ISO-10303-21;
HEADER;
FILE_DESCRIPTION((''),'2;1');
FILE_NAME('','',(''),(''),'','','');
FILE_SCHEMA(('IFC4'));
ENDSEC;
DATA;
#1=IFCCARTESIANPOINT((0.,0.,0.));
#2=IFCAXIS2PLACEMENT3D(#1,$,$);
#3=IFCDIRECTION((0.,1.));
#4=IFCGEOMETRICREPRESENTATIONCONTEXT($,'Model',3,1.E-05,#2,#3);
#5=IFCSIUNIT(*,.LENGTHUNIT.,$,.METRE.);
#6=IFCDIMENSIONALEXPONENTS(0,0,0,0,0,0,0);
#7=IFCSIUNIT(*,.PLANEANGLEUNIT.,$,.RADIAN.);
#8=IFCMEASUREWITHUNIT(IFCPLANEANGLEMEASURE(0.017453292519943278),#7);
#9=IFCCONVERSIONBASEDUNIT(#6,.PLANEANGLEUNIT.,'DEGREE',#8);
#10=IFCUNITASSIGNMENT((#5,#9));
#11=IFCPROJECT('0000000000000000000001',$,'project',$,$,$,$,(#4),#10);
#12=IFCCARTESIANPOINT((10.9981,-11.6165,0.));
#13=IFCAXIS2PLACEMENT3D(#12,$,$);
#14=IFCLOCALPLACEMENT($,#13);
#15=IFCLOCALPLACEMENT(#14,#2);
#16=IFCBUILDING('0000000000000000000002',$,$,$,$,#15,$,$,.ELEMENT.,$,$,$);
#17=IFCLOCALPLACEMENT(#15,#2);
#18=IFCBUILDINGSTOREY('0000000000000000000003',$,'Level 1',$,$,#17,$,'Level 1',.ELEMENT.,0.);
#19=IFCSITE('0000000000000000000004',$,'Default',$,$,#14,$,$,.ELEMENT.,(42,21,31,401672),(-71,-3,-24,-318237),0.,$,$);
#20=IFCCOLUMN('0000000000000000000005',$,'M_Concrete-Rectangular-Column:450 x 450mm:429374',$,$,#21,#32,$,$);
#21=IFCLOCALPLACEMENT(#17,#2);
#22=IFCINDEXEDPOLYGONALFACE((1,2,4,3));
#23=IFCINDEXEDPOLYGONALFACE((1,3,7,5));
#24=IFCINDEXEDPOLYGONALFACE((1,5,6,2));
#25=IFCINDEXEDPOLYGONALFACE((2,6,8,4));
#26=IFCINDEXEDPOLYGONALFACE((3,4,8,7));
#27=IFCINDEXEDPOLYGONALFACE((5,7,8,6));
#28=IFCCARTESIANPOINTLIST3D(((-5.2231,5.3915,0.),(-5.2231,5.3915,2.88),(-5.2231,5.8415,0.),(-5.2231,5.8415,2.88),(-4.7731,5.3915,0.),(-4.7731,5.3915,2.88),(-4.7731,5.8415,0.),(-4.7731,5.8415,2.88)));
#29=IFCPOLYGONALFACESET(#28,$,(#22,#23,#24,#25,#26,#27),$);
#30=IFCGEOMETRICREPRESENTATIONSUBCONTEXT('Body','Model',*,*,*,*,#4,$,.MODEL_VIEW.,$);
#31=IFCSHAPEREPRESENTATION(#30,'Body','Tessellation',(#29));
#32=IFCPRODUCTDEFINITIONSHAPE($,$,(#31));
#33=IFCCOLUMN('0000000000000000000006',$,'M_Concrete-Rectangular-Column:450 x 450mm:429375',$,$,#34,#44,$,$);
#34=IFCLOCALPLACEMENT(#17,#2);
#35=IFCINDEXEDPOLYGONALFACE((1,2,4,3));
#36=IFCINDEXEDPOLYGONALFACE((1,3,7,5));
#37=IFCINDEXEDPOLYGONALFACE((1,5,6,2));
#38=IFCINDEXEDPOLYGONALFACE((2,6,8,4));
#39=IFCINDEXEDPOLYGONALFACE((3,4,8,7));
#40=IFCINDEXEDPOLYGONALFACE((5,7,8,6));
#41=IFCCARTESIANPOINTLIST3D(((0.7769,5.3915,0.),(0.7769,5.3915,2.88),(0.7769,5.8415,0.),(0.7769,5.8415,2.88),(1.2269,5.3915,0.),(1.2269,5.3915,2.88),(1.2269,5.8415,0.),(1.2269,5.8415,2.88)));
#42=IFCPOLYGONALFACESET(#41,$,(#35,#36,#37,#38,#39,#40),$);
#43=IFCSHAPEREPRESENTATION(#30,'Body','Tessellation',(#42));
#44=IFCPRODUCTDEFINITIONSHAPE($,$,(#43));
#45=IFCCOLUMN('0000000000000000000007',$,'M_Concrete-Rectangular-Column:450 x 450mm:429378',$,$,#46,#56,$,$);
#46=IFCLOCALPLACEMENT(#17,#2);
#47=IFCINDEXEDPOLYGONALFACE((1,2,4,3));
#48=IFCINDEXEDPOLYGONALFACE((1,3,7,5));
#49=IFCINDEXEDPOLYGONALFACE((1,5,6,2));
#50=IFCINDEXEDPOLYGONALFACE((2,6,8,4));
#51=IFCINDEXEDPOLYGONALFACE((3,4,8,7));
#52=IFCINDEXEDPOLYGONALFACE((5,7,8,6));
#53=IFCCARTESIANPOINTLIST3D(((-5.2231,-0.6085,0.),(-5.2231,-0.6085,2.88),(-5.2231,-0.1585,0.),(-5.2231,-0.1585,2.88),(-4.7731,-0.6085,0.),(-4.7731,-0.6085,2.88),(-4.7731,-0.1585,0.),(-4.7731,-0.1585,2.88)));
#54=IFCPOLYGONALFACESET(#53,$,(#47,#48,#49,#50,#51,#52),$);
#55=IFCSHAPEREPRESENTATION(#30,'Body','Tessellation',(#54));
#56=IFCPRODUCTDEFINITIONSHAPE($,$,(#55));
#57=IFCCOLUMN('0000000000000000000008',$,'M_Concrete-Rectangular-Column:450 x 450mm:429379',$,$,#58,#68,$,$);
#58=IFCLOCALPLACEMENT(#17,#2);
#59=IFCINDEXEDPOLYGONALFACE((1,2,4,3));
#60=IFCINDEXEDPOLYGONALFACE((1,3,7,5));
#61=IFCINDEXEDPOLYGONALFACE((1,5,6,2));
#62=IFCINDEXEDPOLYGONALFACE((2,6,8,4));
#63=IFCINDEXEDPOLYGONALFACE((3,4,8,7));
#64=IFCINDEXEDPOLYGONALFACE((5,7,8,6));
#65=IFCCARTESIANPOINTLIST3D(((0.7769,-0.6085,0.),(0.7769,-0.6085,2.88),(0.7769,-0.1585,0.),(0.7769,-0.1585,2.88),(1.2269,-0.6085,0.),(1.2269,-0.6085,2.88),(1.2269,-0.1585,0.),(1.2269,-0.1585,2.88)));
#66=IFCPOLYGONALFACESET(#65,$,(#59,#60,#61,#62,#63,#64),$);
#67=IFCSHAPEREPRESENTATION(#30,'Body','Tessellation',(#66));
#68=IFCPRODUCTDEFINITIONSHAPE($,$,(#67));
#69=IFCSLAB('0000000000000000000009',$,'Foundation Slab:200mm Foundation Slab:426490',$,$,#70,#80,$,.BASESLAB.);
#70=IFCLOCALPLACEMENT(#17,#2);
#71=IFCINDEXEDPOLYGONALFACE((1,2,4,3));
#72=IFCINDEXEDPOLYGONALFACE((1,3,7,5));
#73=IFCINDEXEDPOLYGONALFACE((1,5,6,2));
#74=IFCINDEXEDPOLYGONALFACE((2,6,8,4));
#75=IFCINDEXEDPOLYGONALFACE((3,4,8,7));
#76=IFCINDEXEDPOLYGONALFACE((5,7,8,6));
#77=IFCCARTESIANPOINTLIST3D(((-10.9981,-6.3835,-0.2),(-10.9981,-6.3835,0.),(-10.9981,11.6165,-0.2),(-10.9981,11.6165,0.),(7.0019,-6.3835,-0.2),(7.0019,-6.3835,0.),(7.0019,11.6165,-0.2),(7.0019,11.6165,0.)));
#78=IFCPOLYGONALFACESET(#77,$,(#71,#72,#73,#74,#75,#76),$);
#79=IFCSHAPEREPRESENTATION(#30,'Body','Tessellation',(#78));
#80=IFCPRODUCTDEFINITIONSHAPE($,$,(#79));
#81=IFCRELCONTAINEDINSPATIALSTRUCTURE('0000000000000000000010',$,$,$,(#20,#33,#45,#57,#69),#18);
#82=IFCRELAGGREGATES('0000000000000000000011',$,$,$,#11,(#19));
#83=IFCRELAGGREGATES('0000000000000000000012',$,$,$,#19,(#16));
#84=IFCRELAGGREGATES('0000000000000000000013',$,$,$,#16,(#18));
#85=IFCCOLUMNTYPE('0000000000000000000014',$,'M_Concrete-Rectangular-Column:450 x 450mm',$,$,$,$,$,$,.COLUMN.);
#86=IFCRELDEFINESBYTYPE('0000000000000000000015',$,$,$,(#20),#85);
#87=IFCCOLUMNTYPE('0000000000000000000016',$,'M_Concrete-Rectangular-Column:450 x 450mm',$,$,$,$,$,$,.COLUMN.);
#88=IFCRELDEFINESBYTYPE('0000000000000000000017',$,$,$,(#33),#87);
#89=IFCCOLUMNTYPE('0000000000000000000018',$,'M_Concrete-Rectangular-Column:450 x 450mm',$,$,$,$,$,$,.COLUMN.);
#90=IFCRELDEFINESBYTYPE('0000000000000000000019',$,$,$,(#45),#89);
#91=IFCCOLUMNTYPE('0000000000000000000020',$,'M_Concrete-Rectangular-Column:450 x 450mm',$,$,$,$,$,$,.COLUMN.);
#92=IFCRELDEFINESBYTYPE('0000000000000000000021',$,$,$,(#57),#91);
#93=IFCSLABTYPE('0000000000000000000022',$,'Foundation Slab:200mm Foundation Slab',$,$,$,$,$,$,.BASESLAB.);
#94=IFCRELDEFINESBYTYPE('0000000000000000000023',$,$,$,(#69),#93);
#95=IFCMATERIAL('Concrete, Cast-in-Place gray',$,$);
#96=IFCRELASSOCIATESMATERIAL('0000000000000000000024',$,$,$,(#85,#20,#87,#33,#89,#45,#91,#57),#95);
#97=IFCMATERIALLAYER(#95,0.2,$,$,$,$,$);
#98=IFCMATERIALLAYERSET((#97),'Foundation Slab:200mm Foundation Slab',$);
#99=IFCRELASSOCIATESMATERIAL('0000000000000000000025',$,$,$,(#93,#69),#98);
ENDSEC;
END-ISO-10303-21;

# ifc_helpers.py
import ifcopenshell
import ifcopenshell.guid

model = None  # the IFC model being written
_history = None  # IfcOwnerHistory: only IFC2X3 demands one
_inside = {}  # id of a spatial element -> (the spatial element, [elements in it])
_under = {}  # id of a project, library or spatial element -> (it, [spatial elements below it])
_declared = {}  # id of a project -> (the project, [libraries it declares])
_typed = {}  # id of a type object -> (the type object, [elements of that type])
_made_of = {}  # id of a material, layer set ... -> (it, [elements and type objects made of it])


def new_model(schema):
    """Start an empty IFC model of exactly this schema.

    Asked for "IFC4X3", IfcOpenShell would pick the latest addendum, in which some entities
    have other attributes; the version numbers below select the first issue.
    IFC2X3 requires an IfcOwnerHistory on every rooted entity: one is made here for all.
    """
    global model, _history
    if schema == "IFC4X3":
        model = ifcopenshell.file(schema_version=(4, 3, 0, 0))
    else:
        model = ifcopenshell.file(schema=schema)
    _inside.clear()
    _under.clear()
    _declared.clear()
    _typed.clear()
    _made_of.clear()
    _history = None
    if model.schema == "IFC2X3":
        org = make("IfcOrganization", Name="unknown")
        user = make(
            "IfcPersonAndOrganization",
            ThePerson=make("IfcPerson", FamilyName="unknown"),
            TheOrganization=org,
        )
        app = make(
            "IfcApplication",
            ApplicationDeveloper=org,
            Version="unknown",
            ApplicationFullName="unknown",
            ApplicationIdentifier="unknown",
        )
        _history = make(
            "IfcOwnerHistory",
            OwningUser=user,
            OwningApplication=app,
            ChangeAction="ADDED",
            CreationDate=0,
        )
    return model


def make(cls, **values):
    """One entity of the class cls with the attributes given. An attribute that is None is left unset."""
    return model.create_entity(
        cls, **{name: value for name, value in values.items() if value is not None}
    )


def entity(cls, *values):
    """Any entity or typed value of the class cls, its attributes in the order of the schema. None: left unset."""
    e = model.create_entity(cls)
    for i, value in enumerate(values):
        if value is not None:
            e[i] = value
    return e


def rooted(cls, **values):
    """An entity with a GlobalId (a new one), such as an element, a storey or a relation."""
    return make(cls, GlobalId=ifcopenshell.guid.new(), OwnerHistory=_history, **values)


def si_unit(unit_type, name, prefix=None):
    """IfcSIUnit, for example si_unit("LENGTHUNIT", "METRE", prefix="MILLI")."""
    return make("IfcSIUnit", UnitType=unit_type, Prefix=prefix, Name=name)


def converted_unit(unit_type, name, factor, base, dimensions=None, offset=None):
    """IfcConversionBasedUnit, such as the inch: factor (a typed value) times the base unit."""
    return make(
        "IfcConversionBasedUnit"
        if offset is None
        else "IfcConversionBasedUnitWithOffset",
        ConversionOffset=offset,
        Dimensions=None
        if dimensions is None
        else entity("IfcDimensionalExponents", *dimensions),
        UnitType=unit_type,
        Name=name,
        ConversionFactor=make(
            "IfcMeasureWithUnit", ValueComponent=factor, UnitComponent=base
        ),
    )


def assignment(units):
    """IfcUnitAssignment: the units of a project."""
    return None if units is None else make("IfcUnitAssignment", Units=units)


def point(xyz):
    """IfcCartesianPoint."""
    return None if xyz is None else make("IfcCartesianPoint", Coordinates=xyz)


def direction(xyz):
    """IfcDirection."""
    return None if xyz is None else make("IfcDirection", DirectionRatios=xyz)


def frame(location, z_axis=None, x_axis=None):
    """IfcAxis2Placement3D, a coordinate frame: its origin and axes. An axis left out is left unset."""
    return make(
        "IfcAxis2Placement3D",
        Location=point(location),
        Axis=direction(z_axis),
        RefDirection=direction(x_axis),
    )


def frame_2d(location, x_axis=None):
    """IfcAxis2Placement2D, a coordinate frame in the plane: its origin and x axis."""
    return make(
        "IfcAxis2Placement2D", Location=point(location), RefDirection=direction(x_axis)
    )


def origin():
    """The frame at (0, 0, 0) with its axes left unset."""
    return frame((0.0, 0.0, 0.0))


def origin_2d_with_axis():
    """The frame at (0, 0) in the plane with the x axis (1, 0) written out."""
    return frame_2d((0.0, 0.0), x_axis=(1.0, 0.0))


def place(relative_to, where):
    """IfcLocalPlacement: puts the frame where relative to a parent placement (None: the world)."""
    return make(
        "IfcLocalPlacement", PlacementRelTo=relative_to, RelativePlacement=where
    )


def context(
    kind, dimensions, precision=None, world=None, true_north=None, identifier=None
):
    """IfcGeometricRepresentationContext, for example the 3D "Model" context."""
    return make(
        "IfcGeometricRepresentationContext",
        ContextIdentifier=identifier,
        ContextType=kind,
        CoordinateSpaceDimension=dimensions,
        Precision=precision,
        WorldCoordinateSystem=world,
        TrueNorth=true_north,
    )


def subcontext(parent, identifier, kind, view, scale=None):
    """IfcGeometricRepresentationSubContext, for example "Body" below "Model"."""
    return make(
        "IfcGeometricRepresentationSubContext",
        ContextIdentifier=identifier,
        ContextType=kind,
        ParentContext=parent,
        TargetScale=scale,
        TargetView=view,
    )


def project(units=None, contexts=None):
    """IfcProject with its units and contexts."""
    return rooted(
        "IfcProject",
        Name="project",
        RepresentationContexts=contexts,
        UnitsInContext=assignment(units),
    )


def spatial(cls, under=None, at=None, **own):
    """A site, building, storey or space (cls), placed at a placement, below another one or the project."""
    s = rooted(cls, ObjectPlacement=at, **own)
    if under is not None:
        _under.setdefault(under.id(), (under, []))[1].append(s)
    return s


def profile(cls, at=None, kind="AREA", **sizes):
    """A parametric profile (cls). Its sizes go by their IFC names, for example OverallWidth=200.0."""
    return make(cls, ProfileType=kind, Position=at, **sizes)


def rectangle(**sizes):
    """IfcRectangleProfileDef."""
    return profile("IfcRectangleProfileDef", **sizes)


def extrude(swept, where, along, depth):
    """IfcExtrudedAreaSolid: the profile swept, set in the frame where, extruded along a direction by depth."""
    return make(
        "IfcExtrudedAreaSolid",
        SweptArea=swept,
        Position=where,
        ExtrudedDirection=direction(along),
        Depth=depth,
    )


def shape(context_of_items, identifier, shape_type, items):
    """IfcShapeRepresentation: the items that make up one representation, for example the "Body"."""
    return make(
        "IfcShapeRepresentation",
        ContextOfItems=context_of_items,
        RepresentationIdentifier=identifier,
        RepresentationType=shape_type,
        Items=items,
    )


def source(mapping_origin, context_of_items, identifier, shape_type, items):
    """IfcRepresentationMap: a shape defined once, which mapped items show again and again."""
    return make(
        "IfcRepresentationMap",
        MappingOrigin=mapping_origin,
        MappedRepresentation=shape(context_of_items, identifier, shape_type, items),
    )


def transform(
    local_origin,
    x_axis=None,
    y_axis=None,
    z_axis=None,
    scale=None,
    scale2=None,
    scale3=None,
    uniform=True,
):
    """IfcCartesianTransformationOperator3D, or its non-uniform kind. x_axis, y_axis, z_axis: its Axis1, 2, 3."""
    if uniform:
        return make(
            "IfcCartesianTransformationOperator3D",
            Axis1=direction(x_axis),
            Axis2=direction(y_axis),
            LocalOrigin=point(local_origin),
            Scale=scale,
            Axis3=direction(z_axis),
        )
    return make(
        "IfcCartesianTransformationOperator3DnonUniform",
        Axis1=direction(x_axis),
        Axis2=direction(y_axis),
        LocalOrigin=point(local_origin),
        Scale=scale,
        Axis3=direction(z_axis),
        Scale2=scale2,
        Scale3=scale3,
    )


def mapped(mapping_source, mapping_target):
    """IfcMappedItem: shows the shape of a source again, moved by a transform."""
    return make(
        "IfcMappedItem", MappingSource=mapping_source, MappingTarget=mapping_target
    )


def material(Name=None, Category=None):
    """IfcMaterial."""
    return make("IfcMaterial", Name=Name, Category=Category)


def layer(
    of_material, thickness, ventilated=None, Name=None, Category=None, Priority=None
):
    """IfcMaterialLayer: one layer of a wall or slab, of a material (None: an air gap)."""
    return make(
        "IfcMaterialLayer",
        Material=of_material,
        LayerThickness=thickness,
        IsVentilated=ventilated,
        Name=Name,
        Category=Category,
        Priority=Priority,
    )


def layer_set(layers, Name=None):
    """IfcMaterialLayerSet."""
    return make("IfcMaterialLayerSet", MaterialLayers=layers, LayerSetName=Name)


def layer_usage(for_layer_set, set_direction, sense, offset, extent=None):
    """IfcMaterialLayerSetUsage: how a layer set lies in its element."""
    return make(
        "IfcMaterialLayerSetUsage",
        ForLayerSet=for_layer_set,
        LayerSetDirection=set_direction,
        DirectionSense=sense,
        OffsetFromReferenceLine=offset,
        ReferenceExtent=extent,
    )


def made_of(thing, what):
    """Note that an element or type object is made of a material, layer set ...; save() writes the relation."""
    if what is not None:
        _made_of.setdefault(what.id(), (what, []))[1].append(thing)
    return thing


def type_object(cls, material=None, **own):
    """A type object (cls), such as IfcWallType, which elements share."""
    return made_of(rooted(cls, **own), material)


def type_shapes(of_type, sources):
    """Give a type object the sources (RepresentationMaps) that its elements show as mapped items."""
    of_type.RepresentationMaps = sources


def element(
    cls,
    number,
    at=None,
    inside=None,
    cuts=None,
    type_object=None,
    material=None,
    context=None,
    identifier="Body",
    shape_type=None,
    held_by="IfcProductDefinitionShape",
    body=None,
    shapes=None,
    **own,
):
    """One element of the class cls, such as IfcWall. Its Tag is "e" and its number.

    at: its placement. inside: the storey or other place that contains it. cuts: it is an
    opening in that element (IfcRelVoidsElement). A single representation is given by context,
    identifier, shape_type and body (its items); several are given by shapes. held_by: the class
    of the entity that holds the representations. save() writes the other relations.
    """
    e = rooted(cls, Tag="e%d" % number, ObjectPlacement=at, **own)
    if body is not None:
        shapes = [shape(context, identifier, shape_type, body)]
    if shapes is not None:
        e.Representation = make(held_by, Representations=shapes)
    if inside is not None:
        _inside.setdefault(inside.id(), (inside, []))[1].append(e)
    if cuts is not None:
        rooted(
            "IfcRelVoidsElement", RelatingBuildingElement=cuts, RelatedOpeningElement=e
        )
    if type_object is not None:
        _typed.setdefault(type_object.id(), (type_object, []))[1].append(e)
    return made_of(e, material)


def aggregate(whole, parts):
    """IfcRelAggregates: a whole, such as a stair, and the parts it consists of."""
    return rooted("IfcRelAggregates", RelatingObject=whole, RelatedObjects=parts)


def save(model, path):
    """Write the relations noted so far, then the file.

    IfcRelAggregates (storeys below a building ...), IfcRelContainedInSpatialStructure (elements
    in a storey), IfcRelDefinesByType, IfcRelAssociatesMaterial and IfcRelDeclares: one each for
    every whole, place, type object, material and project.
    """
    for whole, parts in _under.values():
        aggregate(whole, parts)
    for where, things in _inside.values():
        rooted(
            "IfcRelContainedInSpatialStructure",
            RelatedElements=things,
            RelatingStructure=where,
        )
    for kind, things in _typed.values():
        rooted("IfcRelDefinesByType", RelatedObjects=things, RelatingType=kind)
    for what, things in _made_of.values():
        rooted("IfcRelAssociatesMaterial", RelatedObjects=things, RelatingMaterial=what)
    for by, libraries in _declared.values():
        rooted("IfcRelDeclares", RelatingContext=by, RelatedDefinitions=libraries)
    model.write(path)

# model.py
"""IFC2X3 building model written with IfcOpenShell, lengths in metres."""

from ifc_helpers import new_model, entity, si_unit, converted_unit, direction, frame, frame_2d, origin, origin_2d_with_axis, place, context, subcontext, project, spatial, rectangle, extrude, source, transform, mapped, material, layer, layer_set, layer_usage, type_object, type_shapes, element, save


model = new_model("IFC2X3")

# Units and contexts
model_context = context("Model", 3, precision=1e-05, world=origin(), true_north=direction((0.0, 1.0)))
body_context = subcontext(model_context, "Body", "Model", "MODEL_VIEW")
ifc_project = project(units=[si_unit("LENGTHUNIT", "METRE"), converted_unit("PLANEANGLEUNIT", "DEGREE", entity("IfcPlaneAngleMeasure", 0.017453292519943278), si_unit("PLANEANGLEUNIT", "RADIAN"), dimensions=[0, 0, 0, 0, 0, 0, 0])], contexts=[model_context])

# Site, building, storey
site_placement = place(None, frame((10.9981, -11.6165, 0.0)))
site = spatial("IfcSite", under=ifc_project, at=site_placement, Name="Default", CompositionType="ELEMENT", RefLatitude=(42, 21, 31, 401672), RefLongitude=(-71, -3, -24, -318237), RefElevation=0.0)
building_placement = place(site_placement, origin())
building = spatial("IfcBuilding", under=site, at=building_placement, CompositionType="ELEMENT")
storey_placement = place(building_placement, origin())
storey = spatial("IfcBuildingStorey", under=building, at=storey_placement, Name="Level 1", LongName="Level 1", CompositionType="ELEMENT", Elevation=0.0)

# Columns
ifc_material = material(Name="Concrete, Cast-in-Place gray")
column_type_1 = type_object("IfcColumnType", Name="M_Concrete-Rectangular-Column:450 x 450mm", PredefinedType="COLUMN", material=ifc_material)
shared_shape_1 = source(origin(), body_context, "Body", "SweptSolid", [
    extrude(rectangle(XDim=0.45, YDim=0.45, at=frame_2d((0.0, 0.0), x_axis=(1.0, 0.0))), frame((-4.9981, 5.6165, 0.0), z_axis=(0.0, 0.0, 1.0), x_axis=(-1.0, 0.0, 0.0)), (0.0, 0.0, 1.0), 2.88),
])
type_shapes(column_type_1, [shared_shape_1])
column_1_placement = place(storey_placement, origin())
element("IfcColumn", 1, at=column_1_placement, inside=storey, type_object=column_type_1, material=ifc_material, Name="M_Concrete-Rectangular-Column:450 x 450mm:429374", context=body_context, shape_type="MappedRepresentation", body=[
    mapped(shared_shape_1, transform((0.0, 0.0, 0.0), scale=1.0)),
])
column_type_2 = type_object("IfcColumnType", Name="M_Concrete-Rectangular-Column:450 x 450mm", PredefinedType="COLUMN", material=ifc_material)
shared_shape_2 = source(origin(), body_context, "Body", "SweptSolid", [
    extrude(rectangle(XDim=0.45, YDim=0.45, at=frame_2d((0.0, 0.0), x_axis=(1.0, 0.0))), frame((1.0019, 5.6165, 0.0), z_axis=(0.0, 0.0, 1.0), x_axis=(-1.0, 0.0, 0.0)), (0.0, 0.0, 1.0), 2.88),
])
type_shapes(column_type_2, [shared_shape_2])
column_2_placement = place(storey_placement, origin())
element("IfcColumn", 2, at=column_2_placement, inside=storey, type_object=column_type_2, material=ifc_material, Name="M_Concrete-Rectangular-Column:450 x 450mm:429375", context=body_context, shape_type="MappedRepresentation", body=[
    mapped(shared_shape_2, transform((0.0, 0.0, 0.0), scale=1.0)),
])
column_type_3 = type_object("IfcColumnType", Name="M_Concrete-Rectangular-Column:450 x 450mm", PredefinedType="COLUMN", material=ifc_material)
shared_shape_3 = source(origin(), body_context, "Body", "SweptSolid", [
    extrude(rectangle(XDim=0.45, YDim=0.45, at=frame_2d((0.0, 0.0), x_axis=(1.0, 0.0))), frame((-4.9981, -0.3835, 0.0), z_axis=(0.0, 0.0, 1.0), x_axis=(-1.0, 0.0, 0.0)), (0.0, 0.0, 1.0), 2.88),
])
type_shapes(column_type_3, [shared_shape_3])
column_3_placement = place(storey_placement, origin())
element("IfcColumn", 3, at=column_3_placement, inside=storey, type_object=column_type_3, material=ifc_material, Name="M_Concrete-Rectangular-Column:450 x 450mm:429378", context=body_context, shape_type="MappedRepresentation", body=[
    mapped(shared_shape_3, transform((0.0, 0.0, 0.0), scale=1.0)),
])
column_type_4 = type_object("IfcColumnType", Name="M_Concrete-Rectangular-Column:450 x 450mm", PredefinedType="COLUMN", material=ifc_material)
shared_shape_4 = source(origin(), body_context, "Body", "SweptSolid", [
    extrude(rectangle(XDim=0.45, YDim=0.45, at=frame_2d((0.0, 0.0), x_axis=(1.0, 0.0))), frame((1.0019, -0.3835, 0.0), z_axis=(0.0, 0.0, 1.0), x_axis=(-1.0, 0.0, 0.0)), (0.0, 0.0, 1.0), 2.88),
])
type_shapes(column_type_4, [shared_shape_4])
column_4_placement = place(storey_placement, origin())
element("IfcColumn", 4, at=column_4_placement, inside=storey, type_object=column_type_4, material=ifc_material, Name="M_Concrete-Rectangular-Column:450 x 450mm:429379", context=body_context, shape_type="MappedRepresentation", body=[
    mapped(shared_shape_4, transform((0.0, 0.0, 0.0), scale=1.0)),
])

# Slab
ifc_layer = layer(ifc_material, 0.2)
ifc_layer_set = layer_set([ifc_layer], Name="Foundation Slab:200mm Foundation Slab")
ifc_layer_usage = layer_usage(ifc_layer_set, "AXIS3", "POSITIVE", 0.0)
slab_type = type_object("IfcSlabType", Name="Foundation Slab:200mm Foundation Slab", PredefinedType="BASESLAB", material=ifc_layer_set)
slab_placement = place(storey_placement, origin())
element("IfcSlab", 5, at=slab_placement, inside=storey, type_object=slab_type, material=ifc_layer_usage, Name="Foundation Slab:200mm Foundation Slab:426490", PredefinedType="BASESLAB", context=body_context, shape_type="SweptSolid", body=[
    extrude(rectangle(XDim=18.0, YDim=18.0, at=origin_2d_with_axis()), frame((-1.9981, 2.6165, 0.0), z_axis=(0.0, 0.0, -1.0), x_axis=(0.0, 1.0, 0.0)), (0.0, 0.0, 1.0), 0.2),
])

save(model, "model.ifc")
